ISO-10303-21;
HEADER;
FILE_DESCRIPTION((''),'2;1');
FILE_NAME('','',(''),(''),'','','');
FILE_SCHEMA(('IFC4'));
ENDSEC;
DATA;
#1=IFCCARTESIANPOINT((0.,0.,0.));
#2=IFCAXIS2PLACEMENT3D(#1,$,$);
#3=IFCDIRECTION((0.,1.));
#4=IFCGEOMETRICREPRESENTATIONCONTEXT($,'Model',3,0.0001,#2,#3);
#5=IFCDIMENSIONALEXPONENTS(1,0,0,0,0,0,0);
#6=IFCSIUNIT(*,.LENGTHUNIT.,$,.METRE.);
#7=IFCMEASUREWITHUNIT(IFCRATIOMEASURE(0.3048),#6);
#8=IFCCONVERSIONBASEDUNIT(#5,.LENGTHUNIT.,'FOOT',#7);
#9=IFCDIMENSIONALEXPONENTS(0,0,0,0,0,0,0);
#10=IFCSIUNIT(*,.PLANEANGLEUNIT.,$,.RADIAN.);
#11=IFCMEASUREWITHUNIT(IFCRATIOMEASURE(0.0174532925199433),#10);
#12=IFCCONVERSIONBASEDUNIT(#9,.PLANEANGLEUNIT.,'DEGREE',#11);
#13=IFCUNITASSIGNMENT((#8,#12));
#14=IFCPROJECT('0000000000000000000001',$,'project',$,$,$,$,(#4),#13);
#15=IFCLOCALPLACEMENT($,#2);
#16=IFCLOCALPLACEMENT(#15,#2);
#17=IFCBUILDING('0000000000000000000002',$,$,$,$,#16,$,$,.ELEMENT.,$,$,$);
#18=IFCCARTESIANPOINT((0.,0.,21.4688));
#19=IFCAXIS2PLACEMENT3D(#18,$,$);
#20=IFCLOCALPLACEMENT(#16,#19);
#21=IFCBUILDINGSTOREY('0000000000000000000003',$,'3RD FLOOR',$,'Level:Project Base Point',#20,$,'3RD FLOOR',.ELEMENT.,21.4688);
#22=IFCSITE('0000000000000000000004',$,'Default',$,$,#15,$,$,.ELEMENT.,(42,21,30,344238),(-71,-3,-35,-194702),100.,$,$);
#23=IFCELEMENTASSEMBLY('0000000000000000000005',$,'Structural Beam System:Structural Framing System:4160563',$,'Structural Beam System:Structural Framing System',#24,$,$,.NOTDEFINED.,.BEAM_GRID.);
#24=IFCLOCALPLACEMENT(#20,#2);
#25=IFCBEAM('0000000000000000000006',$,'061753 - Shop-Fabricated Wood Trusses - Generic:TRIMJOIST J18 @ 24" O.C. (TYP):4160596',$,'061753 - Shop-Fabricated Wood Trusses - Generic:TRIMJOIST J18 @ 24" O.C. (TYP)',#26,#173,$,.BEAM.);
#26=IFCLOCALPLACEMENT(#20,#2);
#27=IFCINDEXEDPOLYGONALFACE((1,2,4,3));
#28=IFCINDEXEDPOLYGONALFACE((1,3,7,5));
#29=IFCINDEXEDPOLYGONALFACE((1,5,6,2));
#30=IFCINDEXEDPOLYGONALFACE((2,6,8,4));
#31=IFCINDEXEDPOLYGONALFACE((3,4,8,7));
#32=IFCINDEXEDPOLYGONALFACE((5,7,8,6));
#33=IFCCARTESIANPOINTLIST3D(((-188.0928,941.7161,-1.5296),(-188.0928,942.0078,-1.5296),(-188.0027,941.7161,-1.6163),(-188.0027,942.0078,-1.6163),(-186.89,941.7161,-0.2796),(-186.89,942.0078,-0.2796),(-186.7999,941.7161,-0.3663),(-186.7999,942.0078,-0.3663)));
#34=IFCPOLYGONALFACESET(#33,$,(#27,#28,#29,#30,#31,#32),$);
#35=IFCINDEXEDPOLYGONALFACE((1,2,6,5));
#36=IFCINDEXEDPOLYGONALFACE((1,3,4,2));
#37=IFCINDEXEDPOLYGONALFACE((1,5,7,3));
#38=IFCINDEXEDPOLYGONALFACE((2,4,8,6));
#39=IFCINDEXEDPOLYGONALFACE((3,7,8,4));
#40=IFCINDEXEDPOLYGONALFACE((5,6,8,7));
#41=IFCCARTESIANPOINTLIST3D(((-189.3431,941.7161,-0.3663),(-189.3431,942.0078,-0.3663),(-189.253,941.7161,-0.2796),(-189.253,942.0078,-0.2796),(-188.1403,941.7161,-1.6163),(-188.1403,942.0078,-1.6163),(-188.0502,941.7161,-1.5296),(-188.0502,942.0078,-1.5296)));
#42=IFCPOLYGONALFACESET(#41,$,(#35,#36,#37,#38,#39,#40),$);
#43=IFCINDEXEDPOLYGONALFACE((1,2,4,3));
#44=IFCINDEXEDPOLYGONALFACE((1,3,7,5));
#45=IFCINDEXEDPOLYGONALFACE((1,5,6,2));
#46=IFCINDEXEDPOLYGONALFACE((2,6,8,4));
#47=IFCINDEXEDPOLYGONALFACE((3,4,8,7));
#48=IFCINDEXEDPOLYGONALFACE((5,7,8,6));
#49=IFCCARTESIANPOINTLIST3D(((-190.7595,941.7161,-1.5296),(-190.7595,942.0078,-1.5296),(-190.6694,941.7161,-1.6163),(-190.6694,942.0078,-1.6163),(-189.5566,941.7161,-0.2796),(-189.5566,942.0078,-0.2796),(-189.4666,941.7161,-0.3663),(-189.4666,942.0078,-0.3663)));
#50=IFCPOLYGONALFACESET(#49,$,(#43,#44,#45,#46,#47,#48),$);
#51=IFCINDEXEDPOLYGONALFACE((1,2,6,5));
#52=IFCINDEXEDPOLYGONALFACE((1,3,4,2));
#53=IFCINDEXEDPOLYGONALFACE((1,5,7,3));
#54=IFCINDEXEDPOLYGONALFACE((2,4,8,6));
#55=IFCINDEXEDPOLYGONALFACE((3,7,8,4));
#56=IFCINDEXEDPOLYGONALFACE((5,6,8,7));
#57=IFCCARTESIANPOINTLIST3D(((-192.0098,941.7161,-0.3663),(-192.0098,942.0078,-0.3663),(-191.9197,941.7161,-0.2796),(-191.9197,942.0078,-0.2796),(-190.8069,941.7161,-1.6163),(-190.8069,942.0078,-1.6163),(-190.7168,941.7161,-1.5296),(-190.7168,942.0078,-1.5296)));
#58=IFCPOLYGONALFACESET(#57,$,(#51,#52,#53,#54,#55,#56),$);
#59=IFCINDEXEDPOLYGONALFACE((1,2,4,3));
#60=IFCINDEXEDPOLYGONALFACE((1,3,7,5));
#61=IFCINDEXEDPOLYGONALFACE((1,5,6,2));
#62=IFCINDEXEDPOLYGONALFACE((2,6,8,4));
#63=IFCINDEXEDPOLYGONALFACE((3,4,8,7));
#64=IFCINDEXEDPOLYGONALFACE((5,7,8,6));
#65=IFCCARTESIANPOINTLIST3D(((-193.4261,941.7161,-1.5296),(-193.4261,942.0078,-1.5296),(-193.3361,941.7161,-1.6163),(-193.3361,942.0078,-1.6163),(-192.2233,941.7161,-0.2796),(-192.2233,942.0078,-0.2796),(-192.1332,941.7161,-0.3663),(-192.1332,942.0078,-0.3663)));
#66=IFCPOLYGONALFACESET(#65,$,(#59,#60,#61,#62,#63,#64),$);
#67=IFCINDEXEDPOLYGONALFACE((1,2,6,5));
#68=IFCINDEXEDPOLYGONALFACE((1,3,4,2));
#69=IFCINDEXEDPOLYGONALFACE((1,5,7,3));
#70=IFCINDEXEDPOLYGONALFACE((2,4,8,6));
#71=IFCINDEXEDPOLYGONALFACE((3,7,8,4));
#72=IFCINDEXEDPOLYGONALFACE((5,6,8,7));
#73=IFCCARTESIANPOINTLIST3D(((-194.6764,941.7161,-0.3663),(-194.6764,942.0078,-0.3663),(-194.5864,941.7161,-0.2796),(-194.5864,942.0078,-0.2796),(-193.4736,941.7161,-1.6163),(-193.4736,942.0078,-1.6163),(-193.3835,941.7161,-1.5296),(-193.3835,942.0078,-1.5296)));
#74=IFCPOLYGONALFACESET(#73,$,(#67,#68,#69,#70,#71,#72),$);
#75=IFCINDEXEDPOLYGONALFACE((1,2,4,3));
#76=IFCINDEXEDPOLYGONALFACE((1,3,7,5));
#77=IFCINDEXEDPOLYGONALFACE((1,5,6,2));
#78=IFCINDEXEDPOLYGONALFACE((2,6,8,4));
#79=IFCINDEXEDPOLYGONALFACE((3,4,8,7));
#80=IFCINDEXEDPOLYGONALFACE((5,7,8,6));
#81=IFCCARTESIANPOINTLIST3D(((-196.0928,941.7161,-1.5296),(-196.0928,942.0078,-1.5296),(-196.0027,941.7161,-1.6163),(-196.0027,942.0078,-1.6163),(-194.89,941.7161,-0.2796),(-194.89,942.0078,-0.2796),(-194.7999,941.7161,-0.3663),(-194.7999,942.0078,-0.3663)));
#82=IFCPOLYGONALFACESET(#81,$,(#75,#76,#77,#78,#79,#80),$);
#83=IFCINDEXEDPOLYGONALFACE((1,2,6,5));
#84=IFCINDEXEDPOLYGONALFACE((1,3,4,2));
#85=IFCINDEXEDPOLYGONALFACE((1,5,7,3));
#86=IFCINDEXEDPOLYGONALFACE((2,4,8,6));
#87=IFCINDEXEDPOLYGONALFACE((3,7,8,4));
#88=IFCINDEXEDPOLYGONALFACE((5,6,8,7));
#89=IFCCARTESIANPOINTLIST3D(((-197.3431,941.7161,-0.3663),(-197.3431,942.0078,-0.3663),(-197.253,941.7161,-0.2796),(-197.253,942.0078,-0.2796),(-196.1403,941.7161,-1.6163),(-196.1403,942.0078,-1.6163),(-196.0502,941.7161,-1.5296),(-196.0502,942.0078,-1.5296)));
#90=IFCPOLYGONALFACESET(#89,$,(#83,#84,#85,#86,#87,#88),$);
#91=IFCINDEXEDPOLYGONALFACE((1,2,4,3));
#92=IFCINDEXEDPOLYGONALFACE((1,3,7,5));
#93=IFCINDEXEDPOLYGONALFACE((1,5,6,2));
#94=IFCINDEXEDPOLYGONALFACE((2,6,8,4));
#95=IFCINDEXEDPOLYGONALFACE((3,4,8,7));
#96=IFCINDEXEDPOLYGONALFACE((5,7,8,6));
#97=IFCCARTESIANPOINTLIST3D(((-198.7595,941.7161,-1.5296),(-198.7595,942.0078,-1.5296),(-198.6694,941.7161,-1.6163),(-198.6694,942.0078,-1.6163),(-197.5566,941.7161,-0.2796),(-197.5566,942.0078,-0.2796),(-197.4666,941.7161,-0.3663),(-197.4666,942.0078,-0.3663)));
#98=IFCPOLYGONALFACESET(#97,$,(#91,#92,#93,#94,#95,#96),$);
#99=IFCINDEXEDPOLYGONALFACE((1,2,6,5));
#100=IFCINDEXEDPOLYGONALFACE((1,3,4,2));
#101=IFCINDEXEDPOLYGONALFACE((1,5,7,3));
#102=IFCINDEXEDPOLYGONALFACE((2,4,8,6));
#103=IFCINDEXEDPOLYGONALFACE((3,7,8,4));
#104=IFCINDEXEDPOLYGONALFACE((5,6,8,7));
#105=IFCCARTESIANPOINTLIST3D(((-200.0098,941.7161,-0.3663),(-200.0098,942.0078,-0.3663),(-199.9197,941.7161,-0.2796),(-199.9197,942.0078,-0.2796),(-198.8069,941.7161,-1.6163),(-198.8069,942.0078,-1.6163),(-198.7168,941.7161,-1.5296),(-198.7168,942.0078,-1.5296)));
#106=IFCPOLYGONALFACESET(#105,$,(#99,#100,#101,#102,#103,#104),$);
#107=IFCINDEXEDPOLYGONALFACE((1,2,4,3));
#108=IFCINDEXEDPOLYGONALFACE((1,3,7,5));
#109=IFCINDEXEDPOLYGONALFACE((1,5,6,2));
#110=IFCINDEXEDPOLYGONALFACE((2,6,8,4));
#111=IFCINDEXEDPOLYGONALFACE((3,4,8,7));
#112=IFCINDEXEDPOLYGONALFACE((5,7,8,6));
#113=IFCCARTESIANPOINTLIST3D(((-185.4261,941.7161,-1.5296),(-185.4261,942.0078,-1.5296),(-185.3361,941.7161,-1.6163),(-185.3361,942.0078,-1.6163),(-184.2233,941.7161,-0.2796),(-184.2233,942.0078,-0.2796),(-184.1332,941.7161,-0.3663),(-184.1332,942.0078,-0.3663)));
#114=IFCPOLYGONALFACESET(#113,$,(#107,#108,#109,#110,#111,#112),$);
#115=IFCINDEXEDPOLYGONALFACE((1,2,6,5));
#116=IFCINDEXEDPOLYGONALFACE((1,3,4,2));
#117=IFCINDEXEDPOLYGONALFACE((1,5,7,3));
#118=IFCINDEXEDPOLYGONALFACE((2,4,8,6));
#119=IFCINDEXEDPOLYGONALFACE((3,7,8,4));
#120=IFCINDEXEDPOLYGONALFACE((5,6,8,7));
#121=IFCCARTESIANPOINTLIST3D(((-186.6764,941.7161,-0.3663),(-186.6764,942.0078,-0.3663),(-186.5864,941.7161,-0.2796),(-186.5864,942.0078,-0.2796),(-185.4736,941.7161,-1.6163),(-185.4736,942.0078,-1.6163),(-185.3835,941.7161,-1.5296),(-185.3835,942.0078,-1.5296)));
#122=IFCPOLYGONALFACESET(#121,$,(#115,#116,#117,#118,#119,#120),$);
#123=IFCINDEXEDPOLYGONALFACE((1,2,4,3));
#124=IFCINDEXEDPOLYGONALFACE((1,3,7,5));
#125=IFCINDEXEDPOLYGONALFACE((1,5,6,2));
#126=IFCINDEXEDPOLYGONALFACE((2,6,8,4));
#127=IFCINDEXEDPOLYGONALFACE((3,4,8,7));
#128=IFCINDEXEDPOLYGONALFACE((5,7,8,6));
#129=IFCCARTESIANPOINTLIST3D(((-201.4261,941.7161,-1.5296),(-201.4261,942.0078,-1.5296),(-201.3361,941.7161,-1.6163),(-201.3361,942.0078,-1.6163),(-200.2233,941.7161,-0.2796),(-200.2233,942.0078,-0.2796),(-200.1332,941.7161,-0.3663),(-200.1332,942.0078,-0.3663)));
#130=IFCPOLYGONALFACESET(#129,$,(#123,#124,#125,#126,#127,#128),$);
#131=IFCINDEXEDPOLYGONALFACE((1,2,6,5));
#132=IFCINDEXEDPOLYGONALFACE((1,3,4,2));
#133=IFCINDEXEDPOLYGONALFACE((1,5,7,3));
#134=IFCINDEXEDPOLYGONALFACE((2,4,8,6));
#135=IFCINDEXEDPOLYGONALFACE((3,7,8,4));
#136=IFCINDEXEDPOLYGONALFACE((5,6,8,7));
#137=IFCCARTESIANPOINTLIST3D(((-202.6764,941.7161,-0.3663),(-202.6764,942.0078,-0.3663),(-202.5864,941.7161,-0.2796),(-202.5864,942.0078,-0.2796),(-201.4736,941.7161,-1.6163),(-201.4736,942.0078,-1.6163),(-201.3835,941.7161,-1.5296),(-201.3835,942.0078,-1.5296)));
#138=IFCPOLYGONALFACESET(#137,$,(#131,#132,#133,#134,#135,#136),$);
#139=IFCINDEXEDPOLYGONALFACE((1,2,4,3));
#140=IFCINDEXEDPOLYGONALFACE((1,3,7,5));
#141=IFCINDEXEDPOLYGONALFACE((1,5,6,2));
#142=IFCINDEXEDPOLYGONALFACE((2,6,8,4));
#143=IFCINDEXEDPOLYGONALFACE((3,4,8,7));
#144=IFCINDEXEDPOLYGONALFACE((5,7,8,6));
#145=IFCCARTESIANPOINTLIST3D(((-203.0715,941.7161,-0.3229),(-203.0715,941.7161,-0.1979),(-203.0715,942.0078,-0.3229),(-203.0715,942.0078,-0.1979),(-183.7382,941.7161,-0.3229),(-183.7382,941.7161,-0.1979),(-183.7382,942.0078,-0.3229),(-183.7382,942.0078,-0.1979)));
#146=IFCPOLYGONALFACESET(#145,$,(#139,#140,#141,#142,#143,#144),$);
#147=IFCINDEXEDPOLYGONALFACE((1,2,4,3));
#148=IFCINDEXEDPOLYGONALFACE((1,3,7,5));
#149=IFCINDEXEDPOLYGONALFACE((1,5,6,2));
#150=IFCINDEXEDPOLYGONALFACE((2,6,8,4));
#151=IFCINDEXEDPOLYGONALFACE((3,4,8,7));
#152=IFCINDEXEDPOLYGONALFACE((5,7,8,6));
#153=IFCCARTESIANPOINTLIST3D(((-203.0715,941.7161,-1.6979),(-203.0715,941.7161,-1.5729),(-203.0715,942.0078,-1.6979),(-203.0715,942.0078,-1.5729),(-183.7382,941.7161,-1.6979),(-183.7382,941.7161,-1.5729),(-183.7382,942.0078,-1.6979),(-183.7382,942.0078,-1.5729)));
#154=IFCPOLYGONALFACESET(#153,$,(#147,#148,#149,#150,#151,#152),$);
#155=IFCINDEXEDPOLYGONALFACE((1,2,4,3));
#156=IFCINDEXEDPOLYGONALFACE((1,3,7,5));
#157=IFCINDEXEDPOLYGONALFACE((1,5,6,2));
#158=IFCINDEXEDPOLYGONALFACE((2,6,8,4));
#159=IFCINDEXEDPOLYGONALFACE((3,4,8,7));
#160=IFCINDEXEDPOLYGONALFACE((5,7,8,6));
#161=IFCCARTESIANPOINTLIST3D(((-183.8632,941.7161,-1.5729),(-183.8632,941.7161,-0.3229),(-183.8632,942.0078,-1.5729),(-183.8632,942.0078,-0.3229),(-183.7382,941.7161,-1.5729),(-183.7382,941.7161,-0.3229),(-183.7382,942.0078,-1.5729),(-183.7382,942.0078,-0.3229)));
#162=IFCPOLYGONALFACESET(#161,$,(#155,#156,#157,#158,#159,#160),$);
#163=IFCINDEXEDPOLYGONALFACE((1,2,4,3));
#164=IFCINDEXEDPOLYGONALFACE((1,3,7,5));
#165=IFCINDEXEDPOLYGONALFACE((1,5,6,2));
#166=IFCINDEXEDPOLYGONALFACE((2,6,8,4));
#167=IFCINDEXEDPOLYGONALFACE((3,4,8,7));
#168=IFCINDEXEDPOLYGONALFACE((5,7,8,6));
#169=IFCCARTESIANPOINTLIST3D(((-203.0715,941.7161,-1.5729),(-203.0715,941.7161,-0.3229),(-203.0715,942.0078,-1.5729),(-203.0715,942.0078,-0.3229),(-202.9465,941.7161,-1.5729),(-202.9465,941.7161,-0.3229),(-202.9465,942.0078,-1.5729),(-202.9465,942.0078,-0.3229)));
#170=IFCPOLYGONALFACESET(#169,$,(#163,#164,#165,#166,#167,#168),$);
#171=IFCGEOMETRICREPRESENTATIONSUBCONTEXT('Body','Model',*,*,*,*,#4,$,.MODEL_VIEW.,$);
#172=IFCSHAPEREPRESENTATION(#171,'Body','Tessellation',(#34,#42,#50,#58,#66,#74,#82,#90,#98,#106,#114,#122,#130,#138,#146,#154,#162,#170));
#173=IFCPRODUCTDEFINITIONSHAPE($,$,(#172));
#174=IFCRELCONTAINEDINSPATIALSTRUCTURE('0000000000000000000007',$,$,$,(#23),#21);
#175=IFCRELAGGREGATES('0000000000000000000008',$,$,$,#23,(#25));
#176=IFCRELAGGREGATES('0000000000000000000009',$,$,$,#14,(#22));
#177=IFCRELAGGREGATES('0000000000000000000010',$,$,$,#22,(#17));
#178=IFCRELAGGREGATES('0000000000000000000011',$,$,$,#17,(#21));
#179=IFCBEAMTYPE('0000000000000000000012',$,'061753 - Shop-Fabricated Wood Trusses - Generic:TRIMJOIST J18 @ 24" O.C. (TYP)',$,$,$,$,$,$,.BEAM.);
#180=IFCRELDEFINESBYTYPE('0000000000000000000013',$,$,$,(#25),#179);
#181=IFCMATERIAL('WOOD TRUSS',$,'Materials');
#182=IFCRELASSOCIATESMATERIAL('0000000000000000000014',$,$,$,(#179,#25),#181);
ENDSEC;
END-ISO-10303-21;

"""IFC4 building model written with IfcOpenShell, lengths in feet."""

from ifc_helpers import new_model, entity, si_unit, converted_unit, direction, frame, frame_2d, origin, origin_2d_with_axis, place, context, subcontext, project, spatial, rectangle, extrude, source, transform, mapped, material, material_profile, profile_set, profile_usage, type_object, type_shapes, element, aggregate, save


model = new_model("IFC4")

# Units and contexts
model_context = context("Model", 3, precision=0.0001, world=origin(), true_north=direction((0.0, 1.0)))
body_context = subcontext(model_context, "Body", "Model", "MODEL_VIEW")
ifc_project = project(units=[converted_unit("LENGTHUNIT", "FOOT", entity("IfcRatioMeasure", 0.3048), si_unit("LENGTHUNIT", "METRE"), dimensions=[1, 0, 0, 0, 0, 0, 0]), converted_unit("PLANEANGLEUNIT", "DEGREE", entity("IfcRatioMeasure", 0.0174532925199433), si_unit("PLANEANGLEUNIT", "RADIAN"), dimensions=[0, 0, 0, 0, 0, 0, 0])], contexts=[model_context])

# Site, building, storey
site_placement = place(None, origin())
site = spatial("IfcSite", under=ifc_project, at=site_placement, Name="Default", CompositionType="ELEMENT", RefLatitude=(42, 21, 30, 344238), RefLongitude=(-71, -3, -35, -194702), RefElevation=100.0)
building_placement = place(site_placement, origin())
building = spatial("IfcBuilding", under=site, at=building_placement, CompositionType="ELEMENT")
storey_placement = place(building_placement, frame((0.0, 0.0, 21.4688)))
storey = spatial("IfcBuildingStorey", under=building, at=storey_placement, Name="3RD FLOOR", ObjectType="Level:Project Base Point", LongName="3RD FLOOR", CompositionType="ELEMENT", Elevation=21.4688)

# Element assembly, beam
ifc_material = material(Name="WOOD TRUSS", Category="Materials")
ifc_material_profile_1 = material_profile(ifc_material, rectangle(XDim=1.7347, YDim=0.125, at=frame_2d((0.0, 0.0), x_axis=(1.0, 0.0))), Name="TRIMJOIST J18 @ 24\" O.C. (TYP)")
ifc_material_profile_2 = material_profile(ifc_material, rectangle(XDim=1.7347, YDim=0.125, at=frame_2d((0.0, 0.0), x_axis=(1.0, 0.0))), Name="TRIMJOIST J18 @ 24\" O.C. (TYP)")
ifc_material_profile_3 = material_profile(ifc_material, rectangle(XDim=1.7347, YDim=0.125, at=frame_2d((0.0, 0.0), x_axis=(1.0, 0.0))), Name="TRIMJOIST J18 @ 24\" O.C. (TYP)")
ifc_material_profile_4 = material_profile(ifc_material, rectangle(XDim=1.7347, YDim=0.125, at=frame_2d((0.0, 0.0), x_axis=(1.0, 0.0))), Name="TRIMJOIST J18 @ 24\" O.C. (TYP)")
ifc_material_profile_5 = material_profile(ifc_material, rectangle(XDim=1.7347, YDim=0.125, at=frame_2d((0.0, 0.0), x_axis=(1.0, 0.0))), Name="TRIMJOIST J18 @ 24\" O.C. (TYP)")
ifc_material_profile_6 = material_profile(ifc_material, rectangle(XDim=1.7347, YDim=0.125, at=frame_2d((0.0, 0.0), x_axis=(1.0, 0.0))), Name="TRIMJOIST J18 @ 24\" O.C. (TYP)")
ifc_material_profile_7 = material_profile(ifc_material, rectangle(XDim=1.7347, YDim=0.125, at=frame_2d((0.0, 0.0), x_axis=(1.0, 0.0))), Name="TRIMJOIST J18 @ 24\" O.C. (TYP)")
ifc_material_profile_8 = material_profile(ifc_material, rectangle(XDim=1.7347, YDim=0.125, at=frame_2d((0.0, 0.0), x_axis=(1.0, 0.0))), Name="TRIMJOIST J18 @ 24\" O.C. (TYP)")
ifc_material_profile_9 = material_profile(ifc_material, rectangle(XDim=1.7347, YDim=0.125, at=frame_2d((0.0, 0.0), x_axis=(1.0, 0.0))), Name="TRIMJOIST J18 @ 24\" O.C. (TYP)")
ifc_material_profile_10 = material_profile(ifc_material, rectangle(XDim=1.7347, YDim=0.125, at=origin_2d_with_axis()), Name="TRIMJOIST J18 @ 24\" O.C. (TYP)")
ifc_material_profile_11 = material_profile(ifc_material, rectangle(XDim=0.125, YDim=0.2917, at=origin_2d_with_axis()), Name="TRIMJOIST J18 @ 24\" O.C. (TYP)")
ifc_material_profile_12 = material_profile(ifc_material, rectangle(XDim=0.125, YDim=0.2917, at=origin_2d_with_axis()), Name="TRIMJOIST J18 @ 24\" O.C. (TYP)")
ifc_material_profile_13 = material_profile(ifc_material, rectangle(XDim=1.25, YDim=0.2917, at=origin_2d_with_axis()), Name="TRIMJOIST J18 @ 24\" O.C. (TYP)")
ifc_material_profile_14 = material_profile(ifc_material, rectangle(XDim=1.25, YDim=0.2917, at=origin_2d_with_axis()), Name="TRIMJOIST J18 @ 24\" O.C. (TYP)")
ifc_profile_set = profile_set([ifc_material_profile_1, ifc_material_profile_2, ifc_material_profile_3, ifc_material_profile_4, ifc_material_profile_5, ifc_material_profile_6, ifc_material_profile_7, ifc_material_profile_8, ifc_material_profile_9, ifc_material_profile_10, ifc_material_profile_11, ifc_material_profile_12, ifc_material_profile_13, ifc_material_profile_14], Name="TRIMJOIST J18 @ 24\" O.C. (TYP)")
beam_type_1 = type_object("IfcBeamType", Name="061753 - Shop-Fabricated Wood Trusses - Generic:TRIMJOIST J18 @ 24\" O.C. (TYP)", PredefinedType="BEAM", material=ifc_profile_set)
shared_shape_1 = source(origin(), body_context, "Body", "SweptSolid", [
    extrude(rectangle(XDim=1.7347, YDim=0.125, at=frame_2d((0.0, 0.0), x_axis=(1.0, 0.0))), frame((5.9585, -0.1458, 0.0), z_axis=(0.0, 1.0, 0.0), x_axis=(0.693383, 0.0, 0.720569)), (0.0, 0.0, 1.0), 0.2917),
    extrude(rectangle(XDim=1.7347, YDim=0.125, at=origin_2d_with_axis()), frame((4.7082, -0.1458, 0.0), z_axis=(0.0, 1.0, 0.0), x_axis=(0.693383, 0.0, -0.720569)), (0.0, 0.0, 1.0), 0.2917),
    extrude(rectangle(XDim=1.7347, YDim=0.125, at=frame_2d((0.0, 0.0), x_axis=(1.0, 0.0))), frame((3.2918, -0.1458, 0.0), z_axis=(0.0, 1.0, 0.0), x_axis=(0.693383, 0.0, 0.720569)), (0.0, 0.0, 1.0), 0.2917),
    extrude(rectangle(XDim=1.7347, YDim=0.125, at=frame_2d((0.0, 0.0), x_axis=(1.0, 0.0))), frame((2.0415, -0.1458, 0.0), z_axis=(0.0, 1.0, 0.0), x_axis=(0.693383, 0.0, -0.720569)), (0.0, 0.0, 1.0), 0.2917),
    extrude(rectangle(XDim=1.7347, YDim=0.125, at=frame_2d((0.0, 0.0), x_axis=(1.0, 0.0))), frame((0.6251, -0.1458, 0.0), z_axis=(0.0, 1.0, 0.0), x_axis=(0.693383, 0.0, 0.720569)), (0.0, 0.0, 1.0), 0.2917),
    extrude(rectangle(XDim=1.7347, YDim=0.125, at=frame_2d((0.0, 0.0), x_axis=(1.0, 0.0))), frame((-0.6251, -0.1458, 0.0), z_axis=(0.0, 1.0, 0.0), x_axis=(0.693383, 0.0, -0.720569)), (0.0, 0.0, 1.0), 0.2917),
    extrude(rectangle(XDim=1.7347, YDim=0.125, at=frame_2d((0.0, 0.0), x_axis=(1.0, 0.0))), frame((-2.0415, -0.1458, 0.0), z_axis=(0.0, 1.0, 0.0), x_axis=(0.693383, 0.0, 0.720569)), (0.0, 0.0, 1.0), 0.2917),
    extrude(rectangle(XDim=1.7347, YDim=0.125, at=origin_2d_with_axis()), frame((-3.2918, -0.1458, 0.0), z_axis=(0.0, 1.0, 0.0), x_axis=(0.693383, 0.0, -0.720569)), (0.0, 0.0, 1.0), 0.2917),
    extrude(rectangle(XDim=1.7347, YDim=0.125, at=frame_2d((0.0, 0.0), x_axis=(1.0, 0.0))), frame((-4.7082, -0.1458, 0.0), z_axis=(0.0, 1.0, 0.0), x_axis=(0.693383, 0.0, 0.720569)), (0.0, 0.0, 1.0), 0.2917),
    extrude(rectangle(XDim=1.7347, YDim=0.125, at=frame_2d((0.0, 0.0), x_axis=(1.0, 0.0))), frame((-5.9585, -0.1458, 0.0), z_axis=(0.0, 1.0, 0.0), x_axis=(0.693383, 0.0, -0.720569)), (0.0, 0.0, 1.0), 0.2917),
    extrude(rectangle(XDim=1.7347, YDim=0.125, at=frame_2d((0.0, 0.0), x_axis=(1.0, 0.0))), frame((8.6251, -0.1458, 0.0), z_axis=(0.0, 1.0, 0.0), x_axis=(0.693383, 0.0, 0.720569)), (0.0, 0.0, 1.0), 0.2917),
    extrude(rectangle(XDim=1.7347, YDim=0.125, at=origin_2d_with_axis()), frame((7.3749, -0.1458, 0.0), z_axis=(0.0, 1.0, 0.0), x_axis=(0.693383, 0.0, -0.720569)), (0.0, 0.0, 1.0), 0.2917),
    extrude(rectangle(XDim=1.7347, YDim=0.125, at=frame_2d((0.0, 0.0), x_axis=(1.0, 0.0))), frame((-7.3749, -0.1458, 0.0), z_axis=(0.0, 1.0, 0.0), x_axis=(0.693383, 0.0, 0.720569)), (0.0, 0.0, 1.0), 0.2917),
    extrude(rectangle(XDim=1.7347, YDim=0.125, at=origin_2d_with_axis()), frame((-8.6251, -0.1458, 0.0), z_axis=(0.0, 1.0, 0.0), x_axis=(0.693383, 0.0, -0.720569)), (0.0, 0.0, 1.0), 0.2917),
    extrude(rectangle(XDim=0.125, YDim=0.2917, at=origin_2d_with_axis()), frame((-9.6667, 0.0, 0.6875), z_axis=(1.0, 0.0, 0.0), x_axis=(0.0, 0.0, -1.0)), (0.0, 0.0, 1.0), 19.3333),
    extrude(rectangle(XDim=0.125, YDim=0.2917, at=origin_2d_with_axis()), frame((-9.6667, 0.0, -0.6875), z_axis=(1.0, 0.0, 0.0), x_axis=(0.0, 0.0, -1.0)), (0.0, 0.0, 1.0), 19.3333),
    extrude(rectangle(XDim=1.25, YDim=0.2917, at=origin_2d_with_axis()), frame((9.5417, 0.0, 0.0), z_axis=(1.0, 0.0, 0.0), x_axis=(0.0, 0.0, -1.0)), (0.0, 0.0, 1.0), 0.125),
    extrude(rectangle(XDim=1.25, YDim=0.2917, at=origin_2d_with_axis()), frame((-9.6667, 0.0, 0.0), z_axis=(1.0, 0.0, 0.0), x_axis=(0.0, 0.0, -1.0)), (0.0, 0.0, 1.0), 0.125),
])
type_shapes(beam_type_1, [shared_shape_1])
assembly_1_placement = place(storey_placement, origin())
assembly_1 = element("IfcElementAssembly", 1, at=assembly_1_placement, inside=storey, Name="Structural Beam System:Structural Framing System:4160563", ObjectType="Structural Beam System:Structural Framing System", AssemblyPlace="NOTDEFINED", PredefinedType="BEAM_GRID")
ifc_profile_usage_1 = profile_usage(ifc_profile_set, cardinal=8)
beam_1_placement = place(assembly_1_placement, frame((-193.4048, 941.8619, -0.9479)))
beam_1 = element("IfcBeam", 2, at=beam_1_placement, type_object=beam_type_1, material=ifc_profile_usage_1, Name="061753 - Shop-Fabricated Wood Trusses - Generic:TRIMJOIST J18 @ 24\" O.C. (TYP):4160596", ObjectType="061753 - Shop-Fabricated Wood Trusses - Generic:TRIMJOIST J18 @ 24\" O.C. (TYP)", PredefinedType="BEAM", context=body_context, shape_type="MappedRepresentation", body=[
    mapped(shared_shape_1, transform((0.0, 0.0, 0.0), scale=1.0)),
])
aggregate(assembly_1, [beam_1])

save(model, "model.ifc")
